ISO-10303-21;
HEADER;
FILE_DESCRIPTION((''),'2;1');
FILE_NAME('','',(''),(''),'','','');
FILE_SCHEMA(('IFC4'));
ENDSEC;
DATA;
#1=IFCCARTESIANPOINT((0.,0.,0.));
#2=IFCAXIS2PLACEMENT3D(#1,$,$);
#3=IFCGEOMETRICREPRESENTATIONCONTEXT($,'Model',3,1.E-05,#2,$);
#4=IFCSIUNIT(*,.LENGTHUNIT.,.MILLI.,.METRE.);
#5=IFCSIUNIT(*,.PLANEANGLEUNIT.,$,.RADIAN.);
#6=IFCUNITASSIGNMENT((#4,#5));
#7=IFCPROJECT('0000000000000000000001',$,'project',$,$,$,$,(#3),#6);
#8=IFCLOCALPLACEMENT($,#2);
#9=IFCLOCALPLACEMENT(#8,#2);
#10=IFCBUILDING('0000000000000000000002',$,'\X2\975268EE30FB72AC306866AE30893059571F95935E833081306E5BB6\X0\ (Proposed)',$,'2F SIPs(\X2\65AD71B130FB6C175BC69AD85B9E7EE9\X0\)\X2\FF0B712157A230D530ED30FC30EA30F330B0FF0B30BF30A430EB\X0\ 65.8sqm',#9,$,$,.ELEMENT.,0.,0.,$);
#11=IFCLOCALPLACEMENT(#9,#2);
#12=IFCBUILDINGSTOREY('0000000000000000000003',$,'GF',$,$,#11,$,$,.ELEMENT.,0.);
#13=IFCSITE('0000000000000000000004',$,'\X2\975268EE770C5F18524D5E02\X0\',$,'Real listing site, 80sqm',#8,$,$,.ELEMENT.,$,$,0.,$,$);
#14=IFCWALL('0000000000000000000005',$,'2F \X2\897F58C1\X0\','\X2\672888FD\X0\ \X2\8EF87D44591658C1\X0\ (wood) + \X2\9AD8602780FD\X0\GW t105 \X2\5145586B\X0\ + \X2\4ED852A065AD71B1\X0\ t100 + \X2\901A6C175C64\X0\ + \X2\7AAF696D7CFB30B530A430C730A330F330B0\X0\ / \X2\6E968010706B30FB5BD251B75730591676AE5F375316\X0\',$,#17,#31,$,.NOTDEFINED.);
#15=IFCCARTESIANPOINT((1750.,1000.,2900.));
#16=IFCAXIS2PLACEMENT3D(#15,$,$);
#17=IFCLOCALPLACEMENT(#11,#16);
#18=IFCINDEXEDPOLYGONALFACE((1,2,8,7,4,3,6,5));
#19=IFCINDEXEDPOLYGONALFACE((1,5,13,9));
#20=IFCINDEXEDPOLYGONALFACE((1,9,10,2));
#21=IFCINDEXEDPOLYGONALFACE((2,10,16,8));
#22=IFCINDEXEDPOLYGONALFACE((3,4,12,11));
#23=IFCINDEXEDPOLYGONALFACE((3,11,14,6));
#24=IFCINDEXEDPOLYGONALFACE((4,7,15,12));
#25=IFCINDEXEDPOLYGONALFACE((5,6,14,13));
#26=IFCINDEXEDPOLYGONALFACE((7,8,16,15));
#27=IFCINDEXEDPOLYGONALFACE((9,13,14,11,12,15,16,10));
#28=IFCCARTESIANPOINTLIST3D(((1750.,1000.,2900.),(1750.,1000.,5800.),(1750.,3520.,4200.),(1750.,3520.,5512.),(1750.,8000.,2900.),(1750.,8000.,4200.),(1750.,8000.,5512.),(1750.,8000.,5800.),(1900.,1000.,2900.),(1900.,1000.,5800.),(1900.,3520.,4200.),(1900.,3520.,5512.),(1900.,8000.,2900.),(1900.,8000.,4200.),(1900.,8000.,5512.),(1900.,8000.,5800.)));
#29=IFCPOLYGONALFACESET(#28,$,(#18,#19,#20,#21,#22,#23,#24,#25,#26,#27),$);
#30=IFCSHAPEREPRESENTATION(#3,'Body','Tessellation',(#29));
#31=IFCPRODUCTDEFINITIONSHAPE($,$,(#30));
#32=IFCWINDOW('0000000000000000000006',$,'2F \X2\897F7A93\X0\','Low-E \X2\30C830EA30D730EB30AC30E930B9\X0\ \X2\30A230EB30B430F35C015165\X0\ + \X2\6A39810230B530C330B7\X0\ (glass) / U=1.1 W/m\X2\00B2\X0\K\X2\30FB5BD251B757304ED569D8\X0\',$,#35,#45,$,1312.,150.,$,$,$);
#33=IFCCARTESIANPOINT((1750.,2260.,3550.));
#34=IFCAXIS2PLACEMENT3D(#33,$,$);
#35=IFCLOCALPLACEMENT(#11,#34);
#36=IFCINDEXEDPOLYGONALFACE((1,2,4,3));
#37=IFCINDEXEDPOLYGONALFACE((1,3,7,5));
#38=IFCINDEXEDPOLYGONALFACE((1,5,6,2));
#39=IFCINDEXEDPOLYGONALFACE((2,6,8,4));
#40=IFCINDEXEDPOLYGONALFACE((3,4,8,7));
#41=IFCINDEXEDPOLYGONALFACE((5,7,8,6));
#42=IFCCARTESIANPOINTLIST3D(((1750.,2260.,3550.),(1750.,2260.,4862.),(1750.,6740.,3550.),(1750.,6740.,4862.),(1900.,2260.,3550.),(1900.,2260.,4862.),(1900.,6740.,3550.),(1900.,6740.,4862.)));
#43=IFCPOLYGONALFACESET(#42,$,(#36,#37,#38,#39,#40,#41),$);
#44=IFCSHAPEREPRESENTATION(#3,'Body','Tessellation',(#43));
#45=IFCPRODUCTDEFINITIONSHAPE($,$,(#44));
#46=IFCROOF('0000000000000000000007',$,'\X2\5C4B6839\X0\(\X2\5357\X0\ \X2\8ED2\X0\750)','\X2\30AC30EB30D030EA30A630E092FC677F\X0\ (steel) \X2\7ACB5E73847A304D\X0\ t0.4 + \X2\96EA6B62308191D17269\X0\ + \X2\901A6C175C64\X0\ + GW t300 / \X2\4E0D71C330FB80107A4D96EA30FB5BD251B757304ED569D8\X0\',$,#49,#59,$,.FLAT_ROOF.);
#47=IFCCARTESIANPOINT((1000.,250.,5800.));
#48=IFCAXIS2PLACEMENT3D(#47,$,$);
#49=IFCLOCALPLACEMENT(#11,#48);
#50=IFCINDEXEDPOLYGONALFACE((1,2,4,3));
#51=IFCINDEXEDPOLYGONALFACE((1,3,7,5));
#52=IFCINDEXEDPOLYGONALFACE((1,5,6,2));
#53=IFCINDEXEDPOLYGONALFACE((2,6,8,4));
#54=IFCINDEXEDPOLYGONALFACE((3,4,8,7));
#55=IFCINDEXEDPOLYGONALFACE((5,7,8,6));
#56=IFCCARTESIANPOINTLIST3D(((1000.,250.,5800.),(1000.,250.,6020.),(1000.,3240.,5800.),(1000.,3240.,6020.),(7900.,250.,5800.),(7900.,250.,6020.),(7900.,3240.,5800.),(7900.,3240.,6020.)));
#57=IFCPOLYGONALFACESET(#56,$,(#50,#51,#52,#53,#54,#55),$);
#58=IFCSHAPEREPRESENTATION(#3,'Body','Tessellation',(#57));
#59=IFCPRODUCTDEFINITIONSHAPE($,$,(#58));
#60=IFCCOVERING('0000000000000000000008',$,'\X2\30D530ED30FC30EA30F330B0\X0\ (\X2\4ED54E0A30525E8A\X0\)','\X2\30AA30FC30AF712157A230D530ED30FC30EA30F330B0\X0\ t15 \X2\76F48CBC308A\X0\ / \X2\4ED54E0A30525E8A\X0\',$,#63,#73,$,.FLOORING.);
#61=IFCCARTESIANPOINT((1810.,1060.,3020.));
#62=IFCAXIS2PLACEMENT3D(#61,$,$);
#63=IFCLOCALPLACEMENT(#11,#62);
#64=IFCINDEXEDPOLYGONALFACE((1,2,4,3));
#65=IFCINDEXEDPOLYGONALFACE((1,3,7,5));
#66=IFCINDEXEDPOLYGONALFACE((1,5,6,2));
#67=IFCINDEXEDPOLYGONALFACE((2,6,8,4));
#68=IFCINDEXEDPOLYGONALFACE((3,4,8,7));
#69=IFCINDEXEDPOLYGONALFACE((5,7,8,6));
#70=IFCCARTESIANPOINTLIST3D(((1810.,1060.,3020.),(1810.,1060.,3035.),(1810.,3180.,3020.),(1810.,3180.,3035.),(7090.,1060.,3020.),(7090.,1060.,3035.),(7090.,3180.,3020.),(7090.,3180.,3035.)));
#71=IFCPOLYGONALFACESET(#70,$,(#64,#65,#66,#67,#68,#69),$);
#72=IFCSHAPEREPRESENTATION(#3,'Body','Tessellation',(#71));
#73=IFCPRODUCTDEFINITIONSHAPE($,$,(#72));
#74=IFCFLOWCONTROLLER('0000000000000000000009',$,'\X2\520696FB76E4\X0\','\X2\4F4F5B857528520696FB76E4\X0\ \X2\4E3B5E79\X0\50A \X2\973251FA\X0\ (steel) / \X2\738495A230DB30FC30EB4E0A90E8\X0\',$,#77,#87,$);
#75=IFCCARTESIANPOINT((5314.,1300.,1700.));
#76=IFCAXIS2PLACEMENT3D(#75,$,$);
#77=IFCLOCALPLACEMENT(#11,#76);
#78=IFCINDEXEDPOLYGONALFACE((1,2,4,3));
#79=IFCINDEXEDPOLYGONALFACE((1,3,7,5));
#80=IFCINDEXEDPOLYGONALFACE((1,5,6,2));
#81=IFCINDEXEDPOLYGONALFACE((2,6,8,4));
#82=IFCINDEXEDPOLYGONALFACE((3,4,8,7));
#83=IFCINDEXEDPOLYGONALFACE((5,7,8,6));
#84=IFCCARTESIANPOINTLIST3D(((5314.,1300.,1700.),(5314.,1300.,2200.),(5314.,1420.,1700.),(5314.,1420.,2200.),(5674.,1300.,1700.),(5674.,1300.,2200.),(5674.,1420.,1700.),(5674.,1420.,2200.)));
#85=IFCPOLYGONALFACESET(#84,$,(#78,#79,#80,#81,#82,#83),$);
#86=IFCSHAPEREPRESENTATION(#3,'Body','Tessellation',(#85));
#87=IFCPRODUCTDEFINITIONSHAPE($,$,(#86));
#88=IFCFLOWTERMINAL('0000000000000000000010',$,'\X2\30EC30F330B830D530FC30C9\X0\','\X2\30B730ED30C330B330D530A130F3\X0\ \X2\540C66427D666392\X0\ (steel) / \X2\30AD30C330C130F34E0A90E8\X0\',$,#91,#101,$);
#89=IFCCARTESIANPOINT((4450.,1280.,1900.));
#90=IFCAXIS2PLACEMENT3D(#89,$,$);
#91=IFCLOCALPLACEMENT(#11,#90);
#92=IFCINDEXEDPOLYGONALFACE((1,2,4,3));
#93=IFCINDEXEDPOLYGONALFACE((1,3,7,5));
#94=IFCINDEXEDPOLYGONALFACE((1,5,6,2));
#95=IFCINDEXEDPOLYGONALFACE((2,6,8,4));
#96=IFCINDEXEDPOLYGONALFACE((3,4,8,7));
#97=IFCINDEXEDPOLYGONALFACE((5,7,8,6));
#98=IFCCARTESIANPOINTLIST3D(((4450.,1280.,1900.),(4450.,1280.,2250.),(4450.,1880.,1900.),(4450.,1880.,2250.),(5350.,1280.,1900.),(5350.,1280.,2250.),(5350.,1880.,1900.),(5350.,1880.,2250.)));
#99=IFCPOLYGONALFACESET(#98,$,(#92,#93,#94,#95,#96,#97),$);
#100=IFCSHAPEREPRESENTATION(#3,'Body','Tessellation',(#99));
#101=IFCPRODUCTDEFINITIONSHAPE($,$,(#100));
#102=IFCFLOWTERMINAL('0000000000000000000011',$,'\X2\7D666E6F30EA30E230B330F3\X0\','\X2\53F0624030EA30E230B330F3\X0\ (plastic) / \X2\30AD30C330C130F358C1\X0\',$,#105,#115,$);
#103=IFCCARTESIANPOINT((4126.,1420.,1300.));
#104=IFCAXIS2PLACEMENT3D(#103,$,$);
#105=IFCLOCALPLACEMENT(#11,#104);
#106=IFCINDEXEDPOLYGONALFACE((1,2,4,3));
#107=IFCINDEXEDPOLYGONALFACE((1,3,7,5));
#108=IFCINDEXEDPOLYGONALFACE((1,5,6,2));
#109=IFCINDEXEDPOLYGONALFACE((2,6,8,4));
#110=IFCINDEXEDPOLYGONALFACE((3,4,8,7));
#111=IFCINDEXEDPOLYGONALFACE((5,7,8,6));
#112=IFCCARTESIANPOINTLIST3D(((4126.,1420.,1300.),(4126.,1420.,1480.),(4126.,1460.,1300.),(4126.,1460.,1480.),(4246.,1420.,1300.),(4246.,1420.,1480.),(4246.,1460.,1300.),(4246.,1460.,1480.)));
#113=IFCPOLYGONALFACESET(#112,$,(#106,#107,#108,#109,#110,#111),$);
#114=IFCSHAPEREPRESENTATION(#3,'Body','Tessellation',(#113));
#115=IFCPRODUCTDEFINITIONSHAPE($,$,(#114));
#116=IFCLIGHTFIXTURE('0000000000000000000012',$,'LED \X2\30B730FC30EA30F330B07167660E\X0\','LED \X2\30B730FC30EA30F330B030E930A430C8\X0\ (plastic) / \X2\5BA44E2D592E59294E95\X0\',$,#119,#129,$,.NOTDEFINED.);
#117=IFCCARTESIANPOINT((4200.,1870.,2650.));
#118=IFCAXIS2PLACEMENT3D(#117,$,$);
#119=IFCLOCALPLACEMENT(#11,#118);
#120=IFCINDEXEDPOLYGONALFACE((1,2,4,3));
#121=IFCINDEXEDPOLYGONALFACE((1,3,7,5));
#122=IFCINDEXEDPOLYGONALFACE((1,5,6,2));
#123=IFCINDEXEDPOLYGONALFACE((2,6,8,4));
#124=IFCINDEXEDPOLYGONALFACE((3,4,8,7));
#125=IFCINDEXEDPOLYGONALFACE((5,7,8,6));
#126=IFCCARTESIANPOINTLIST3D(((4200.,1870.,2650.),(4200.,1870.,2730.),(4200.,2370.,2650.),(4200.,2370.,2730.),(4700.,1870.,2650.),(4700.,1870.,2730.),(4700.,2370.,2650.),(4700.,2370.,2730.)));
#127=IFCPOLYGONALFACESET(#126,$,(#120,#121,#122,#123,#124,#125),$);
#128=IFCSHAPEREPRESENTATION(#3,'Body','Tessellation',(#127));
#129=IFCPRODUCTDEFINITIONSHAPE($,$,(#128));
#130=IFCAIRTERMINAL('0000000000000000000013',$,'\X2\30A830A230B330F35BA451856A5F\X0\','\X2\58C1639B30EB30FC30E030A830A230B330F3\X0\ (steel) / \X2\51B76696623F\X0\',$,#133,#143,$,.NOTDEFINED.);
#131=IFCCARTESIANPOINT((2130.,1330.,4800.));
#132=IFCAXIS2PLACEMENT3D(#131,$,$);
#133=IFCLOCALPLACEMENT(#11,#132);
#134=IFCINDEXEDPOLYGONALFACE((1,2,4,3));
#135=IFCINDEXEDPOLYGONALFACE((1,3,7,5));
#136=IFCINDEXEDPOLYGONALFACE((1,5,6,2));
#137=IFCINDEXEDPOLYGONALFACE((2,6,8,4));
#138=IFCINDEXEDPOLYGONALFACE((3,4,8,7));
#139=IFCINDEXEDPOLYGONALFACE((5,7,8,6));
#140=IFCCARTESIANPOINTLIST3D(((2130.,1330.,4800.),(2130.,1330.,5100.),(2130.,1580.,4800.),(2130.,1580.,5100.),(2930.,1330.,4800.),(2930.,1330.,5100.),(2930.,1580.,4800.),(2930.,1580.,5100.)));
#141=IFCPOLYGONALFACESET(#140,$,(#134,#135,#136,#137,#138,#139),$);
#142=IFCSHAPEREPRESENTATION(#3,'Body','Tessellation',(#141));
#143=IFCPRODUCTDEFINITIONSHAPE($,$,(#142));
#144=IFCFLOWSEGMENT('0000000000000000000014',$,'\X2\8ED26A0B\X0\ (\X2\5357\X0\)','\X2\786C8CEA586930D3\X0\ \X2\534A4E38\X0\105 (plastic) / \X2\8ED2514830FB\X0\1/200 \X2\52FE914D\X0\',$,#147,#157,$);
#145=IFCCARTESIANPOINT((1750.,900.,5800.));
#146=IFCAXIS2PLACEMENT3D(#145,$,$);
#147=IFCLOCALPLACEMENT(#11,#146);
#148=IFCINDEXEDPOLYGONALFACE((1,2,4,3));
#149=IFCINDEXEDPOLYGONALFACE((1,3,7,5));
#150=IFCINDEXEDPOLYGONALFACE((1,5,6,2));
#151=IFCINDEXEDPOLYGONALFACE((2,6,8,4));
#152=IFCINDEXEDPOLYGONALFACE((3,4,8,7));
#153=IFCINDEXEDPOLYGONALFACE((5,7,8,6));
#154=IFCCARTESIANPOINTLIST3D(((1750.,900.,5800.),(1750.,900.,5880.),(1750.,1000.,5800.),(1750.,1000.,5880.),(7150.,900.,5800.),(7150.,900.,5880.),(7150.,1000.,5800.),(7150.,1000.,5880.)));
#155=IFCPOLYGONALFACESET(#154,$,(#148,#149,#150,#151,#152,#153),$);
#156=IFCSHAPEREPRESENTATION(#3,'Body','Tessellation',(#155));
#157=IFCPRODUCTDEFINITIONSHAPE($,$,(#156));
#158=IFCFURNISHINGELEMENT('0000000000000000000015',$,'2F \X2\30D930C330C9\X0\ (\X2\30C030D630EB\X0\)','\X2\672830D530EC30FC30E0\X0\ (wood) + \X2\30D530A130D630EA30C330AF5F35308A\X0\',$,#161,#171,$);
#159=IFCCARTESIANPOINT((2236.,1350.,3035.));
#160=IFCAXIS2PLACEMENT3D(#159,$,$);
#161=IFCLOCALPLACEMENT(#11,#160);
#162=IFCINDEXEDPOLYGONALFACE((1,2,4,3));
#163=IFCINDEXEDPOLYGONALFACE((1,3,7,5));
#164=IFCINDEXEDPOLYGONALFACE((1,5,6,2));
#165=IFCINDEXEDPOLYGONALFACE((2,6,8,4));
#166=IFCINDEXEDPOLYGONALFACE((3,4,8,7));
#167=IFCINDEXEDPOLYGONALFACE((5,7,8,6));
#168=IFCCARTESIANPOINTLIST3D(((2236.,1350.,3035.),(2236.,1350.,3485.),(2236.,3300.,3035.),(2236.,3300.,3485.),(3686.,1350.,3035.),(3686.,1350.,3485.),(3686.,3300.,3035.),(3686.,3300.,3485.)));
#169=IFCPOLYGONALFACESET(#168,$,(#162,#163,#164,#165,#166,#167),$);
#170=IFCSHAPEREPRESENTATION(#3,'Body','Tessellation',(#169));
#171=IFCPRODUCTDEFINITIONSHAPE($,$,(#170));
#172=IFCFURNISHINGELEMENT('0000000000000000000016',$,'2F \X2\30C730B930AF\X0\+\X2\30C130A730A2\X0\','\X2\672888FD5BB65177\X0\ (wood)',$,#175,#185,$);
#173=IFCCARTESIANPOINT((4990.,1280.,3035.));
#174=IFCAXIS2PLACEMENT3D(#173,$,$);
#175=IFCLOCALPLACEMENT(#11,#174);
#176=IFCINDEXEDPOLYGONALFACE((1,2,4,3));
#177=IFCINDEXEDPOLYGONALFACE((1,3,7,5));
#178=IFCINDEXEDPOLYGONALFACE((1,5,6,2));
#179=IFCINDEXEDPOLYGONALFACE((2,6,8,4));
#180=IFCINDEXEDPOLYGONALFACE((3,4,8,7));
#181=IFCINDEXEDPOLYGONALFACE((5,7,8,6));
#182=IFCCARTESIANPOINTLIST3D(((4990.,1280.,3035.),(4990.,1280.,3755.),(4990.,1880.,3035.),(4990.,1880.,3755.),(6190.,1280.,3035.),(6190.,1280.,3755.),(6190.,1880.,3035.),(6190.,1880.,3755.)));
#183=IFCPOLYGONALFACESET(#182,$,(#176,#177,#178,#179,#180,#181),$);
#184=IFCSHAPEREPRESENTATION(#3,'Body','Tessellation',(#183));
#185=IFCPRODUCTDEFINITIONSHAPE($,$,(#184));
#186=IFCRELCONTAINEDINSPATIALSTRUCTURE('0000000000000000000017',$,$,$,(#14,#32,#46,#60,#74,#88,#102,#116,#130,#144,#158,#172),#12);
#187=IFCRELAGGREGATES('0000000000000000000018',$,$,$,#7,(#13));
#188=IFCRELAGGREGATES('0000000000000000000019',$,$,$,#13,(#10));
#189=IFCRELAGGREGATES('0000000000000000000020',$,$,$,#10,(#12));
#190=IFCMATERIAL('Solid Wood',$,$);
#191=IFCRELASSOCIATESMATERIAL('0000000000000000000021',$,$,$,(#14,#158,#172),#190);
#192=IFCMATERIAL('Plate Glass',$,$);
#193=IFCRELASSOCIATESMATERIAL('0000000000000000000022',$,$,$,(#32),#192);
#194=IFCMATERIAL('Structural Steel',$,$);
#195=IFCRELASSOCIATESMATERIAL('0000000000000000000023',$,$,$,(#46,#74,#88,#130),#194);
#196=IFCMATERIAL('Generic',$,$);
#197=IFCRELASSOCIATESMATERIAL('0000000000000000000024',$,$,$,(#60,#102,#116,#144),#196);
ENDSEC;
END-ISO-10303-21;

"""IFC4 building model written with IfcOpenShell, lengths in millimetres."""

from ifc_helpers import new_model, si_unit, frame, frame_2d, origin, place, context, project, spatial, rectangle, extrude, material, element, fill, save


model = new_model("IFC4")

# Units and contexts
model_context = context("Model", 3, precision=1e-05, world=origin())
ifc_project = project(units=[si_unit("LENGTHUNIT", "METRE", prefix="MILLI"), si_unit("PLANEANGLEUNIT", "RADIAN")], contexts=[model_context])

# Site, building, storey
site_placement = place(None, origin())
site = spatial("IfcSite", under=ifc_project, at=site_placement, Name="青森県弘前市", ObjectType="Real listing site, 80sqm", CompositionType="ELEMENT", RefElevation=0.0)
building_placement = place(site_placement, origin())
building = spatial("IfcBuilding", under=site, at=building_placement, Name="青森・犬と暮らす土間広めの家 (Proposed)", ObjectType="2F SIPs(断熱・気密高实绩)＋無垢フローリング＋タイル 65.8sqm", CompositionType="ELEMENT", ElevationOfRefHeight=0.0, ElevationOfTerrain=0.0)
storey_placement = place(building_placement, origin())
storey = spatial("IfcBuildingStorey", under=building, at=storey_placement, Name="GF", CompositionType="ELEMENT", Elevation=0.0)

# Shared definitions
ifc_material_1 = material(Name="Solid Wood")

# Wall, opening, window
ifc_material_2 = material(Name="Plate Glass")
wall_1_placement = place(storey_placement, frame((1750.0, 1000.0, 2900.0)))
wall_1 = element("IfcWall", 1, at=wall_1_placement, inside=storey, material=ifc_material_1, Name="2F 西壁", Description="木製 軸組外壁 (wood) + 高性能GW t105 充填 + 付加断熱 t100 + 通気層 + 窯業系サイディング / 準耐火・寒冷地外皮強化", PredefinedType="NOTDEFINED", context=model_context, shape_type="SweptSolid", body=[
    extrude(rectangle(XDim=150.0, YDim=7000.0, at=frame_2d((75.0, 3500.0))), frame((1750.0, 1000.0, 2900.0)), (0.0, 0.0, 1.0), 2900.0),
])
opening_1_placement = place(storey_placement, frame((1750.0, 2260.0, 3550.0)))
opening_1 = element("IfcOpeningElement", 2, at=opening_1_placement, cuts=wall_1, PredefinedType="NOTDEFINED", context=model_context, shape_type="SweptSolid", body=[
    extrude(rectangle(XDim=150.0, YDim=4480.0, at=frame_2d((75.0, 2240.0))), frame((1750.0, 2260.0, 3550.0)), (0.0, 0.0, 1.0), 1312.0),
])
window_1_placement = place(storey_placement, frame((1750.0, 2260.0, 3550.0)))
window_1 = element("IfcWindow", 3, at=window_1_placement, inside=storey, material=ifc_material_2, Name="2F 西窓", Description="Low-E トリプルガラス アルゴン封入 + 樹脂サッシ (glass) / U=1.1 W/m²K・寒冷地仕様", OverallHeight=1312.0, OverallWidth=150.0, context=model_context, shape_type="SweptSolid", body=[
    extrude(rectangle(XDim=150.0, YDim=4480.0, at=frame_2d((75.0, 2240.0))), frame((1750.0, 2260.0, 3550.0)), (0.0, 0.0, 1.0), 1312.0),
])
fill(opening_1, window_1)

# Roof
ifc_material_3 = material(Name="Structural Steel")
for number, where, name in (
    (4, (1000.0, 250.0, 5800.0), "屋根(南 軒750)"),
):
    element("IfcRoof", number, at=place(storey_placement, frame(where)), inside=storey, material=ifc_material_3, Name=name, Description="ガルバリウム鋼板 (steel) 立平葺き t0.4 + 雪止め金物 + 通気層 + GW t300 / 不燃・耐積雪・寒冷地仕様", PredefinedType="FLAT_ROOF", context=model_context, shape_type="SweptSolid", body=[
        extrude(rectangle(XDim=6900.0, YDim=2990.0, at=frame_2d((3450.0, 1495.0))), frame((1000.0, 250.0, 5800.0)), (0.0, 0.0, 1.0), 220.0),
    ])

# Covering
ifc_material_4 = material(Name="Generic")
covering_placement = place(storey_placement, frame((1810.0, 1060.0, 3020.0)))
element("IfcCovering", 5, at=covering_placement, inside=storey, material=ifc_material_4, Name="フローリング (仕上げ床)", Description="オーク無垢フローリング t15 直貼り / 仕上げ床", PredefinedType="FLOORING", context=model_context, shape_type="SweptSolid", body=[
    extrude(rectangle(XDim=5280.0, YDim=2120.0, at=frame_2d((2640.0, 1060.0))), frame((1810.0, 1060.0, 3020.0)), (0.0, 0.0, 1.0), 15.0),
])

# Flow controller
flow_controller_placement = place(storey_placement, frame((5314.0, 1300.0, 1700.0)))
element("IfcFlowController", 6, at=flow_controller_placement, inside=storey, material=ifc_material_3, Name="分電盤", Description="住宅用分電盤 主幹50A 露出 (steel) / 玄関ホール上部", context=model_context, shape_type="SweptSolid", body=[
    extrude(rectangle(XDim=360.0, YDim=120.0, at=frame_2d((180.0, 60.0))), frame((5314.0, 1300.0, 1700.0)), (0.0, 0.0, 1.0), 500.0),
])

# Flow terminals
flow_terminal_1_placement = place(storey_placement, frame((4450.0, 1280.0, 1900.0)))
element("IfcFlowTerminal", 7, at=flow_terminal_1_placement, inside=storey, material=ifc_material_3, Name="レンジフード", Description="シロッコファン 同時給排 (steel) / キッチン上部", context=model_context, shape_type="SweptSolid", body=[
    extrude(rectangle(XDim=900.0, YDim=600.0, at=frame_2d((450.0, 300.0))), frame((4450.0, 1280.0, 1900.0)), (0.0, 0.0, 1.0), 350.0),
])
flow_terminal_2_placement = place(storey_placement, frame((4126.0, 1420.0, 1300.0)))
element("IfcFlowTerminal", 8, at=flow_terminal_2_placement, inside=storey, material=ifc_material_4, Name="給湯リモコン", Description="台所リモコン (plastic) / キッチン壁", context=model_context, shape_type="SweptSolid", body=[
    extrude(rectangle(XDim=120.0, YDim=40.0, at=frame_2d((60.0, 20.0))), frame((4126.0, 1420.0, 1300.0)), (0.0, 0.0, 1.0), 180.0),
])

# Light fixture
light_fixture_placement = place(storey_placement, frame((4200.0, 1870.0, 2650.0)))
element("IfcLightFixture", 9, at=light_fixture_placement, inside=storey, material=ifc_material_4, Name="LED シーリング照明", Description="LED シーリングライト (plastic) / 室中央天井", PredefinedType="NOTDEFINED", context=model_context, shape_type="SweptSolid", body=[
    extrude(rectangle(XDim=500.0, YDim=500.0, at=frame_2d((250.0, 250.0))), frame((4200.0, 1870.0, 2650.0)), (0.0, 0.0, 1.0), 80.0),
])

# Air terminal
air_terminal_placement = place(storey_placement, frame((2130.0, 1330.0, 4800.0)))
element("IfcAirTerminal", 10, at=air_terminal_placement, inside=storey, material=ifc_material_3, Name="エアコン室内機", Description="壁掛ルームエアコン (steel) / 冷暖房", PredefinedType="NOTDEFINED", context=model_context, shape_type="SweptSolid", body=[
    extrude(rectangle(XDim=800.0, YDim=250.0, at=frame_2d((400.0, 125.0))), frame((2130.0, 1330.0, 4800.0)), (0.0, 0.0, 1.0), 300.0),
])

# Flow segment
flow_segment_placement = place(storey_placement, frame((1750.0, 900.0, 5800.0)))
element("IfcFlowSegment", 11, at=flow_segment_placement, inside=storey, material=ifc_material_4, Name="軒樋 (南)", Description="硬質塩ビ 半丸105 (plastic) / 軒先・1/200 勾配", context=model_context, shape_type="SweptSolid", body=[
    extrude(rectangle(XDim=5400.0, YDim=100.0, at=frame_2d((2700.0, 50.0))), frame((1750.0, 900.0, 5800.0)), (0.0, 0.0, 1.0), 80.0),
])

# Furnishing elements
furnishing_1_placement = place(storey_placement, frame((2236.0, 1350.0, 3035.0)))
element("IfcFurnishingElement", 12, at=furnishing_1_placement, inside=storey, material=ifc_material_1, Name="2F ベッド (ダブル)", Description="木フレーム (wood) + ファブリック張り", context=model_context, shape_type="SweptSolid", body=[
    extrude(rectangle(XDim=1450.0, YDim=1950.0, at=frame_2d((725.0, 975.0))), frame((2236.0, 1350.0, 3035.0)), (0.0, 0.0, 1.0), 450.0),
])
furnishing_2_placement = place(storey_placement, frame((4990.0, 1280.0, 3035.0)))
element("IfcFurnishingElement", 13, at=furnishing_2_placement, inside=storey, material=ifc_material_1, Name="2F デスク+チェア", Description="木製家具 (wood)", context=model_context, shape_type="SweptSolid", body=[
    extrude(rectangle(XDim=1200.0, YDim=600.0, at=frame_2d((600.0, 300.0))), frame((4990.0, 1280.0, 3035.0)), (0.0, 0.0, 1.0), 720.0),
])

save(model, "model.ifc")
